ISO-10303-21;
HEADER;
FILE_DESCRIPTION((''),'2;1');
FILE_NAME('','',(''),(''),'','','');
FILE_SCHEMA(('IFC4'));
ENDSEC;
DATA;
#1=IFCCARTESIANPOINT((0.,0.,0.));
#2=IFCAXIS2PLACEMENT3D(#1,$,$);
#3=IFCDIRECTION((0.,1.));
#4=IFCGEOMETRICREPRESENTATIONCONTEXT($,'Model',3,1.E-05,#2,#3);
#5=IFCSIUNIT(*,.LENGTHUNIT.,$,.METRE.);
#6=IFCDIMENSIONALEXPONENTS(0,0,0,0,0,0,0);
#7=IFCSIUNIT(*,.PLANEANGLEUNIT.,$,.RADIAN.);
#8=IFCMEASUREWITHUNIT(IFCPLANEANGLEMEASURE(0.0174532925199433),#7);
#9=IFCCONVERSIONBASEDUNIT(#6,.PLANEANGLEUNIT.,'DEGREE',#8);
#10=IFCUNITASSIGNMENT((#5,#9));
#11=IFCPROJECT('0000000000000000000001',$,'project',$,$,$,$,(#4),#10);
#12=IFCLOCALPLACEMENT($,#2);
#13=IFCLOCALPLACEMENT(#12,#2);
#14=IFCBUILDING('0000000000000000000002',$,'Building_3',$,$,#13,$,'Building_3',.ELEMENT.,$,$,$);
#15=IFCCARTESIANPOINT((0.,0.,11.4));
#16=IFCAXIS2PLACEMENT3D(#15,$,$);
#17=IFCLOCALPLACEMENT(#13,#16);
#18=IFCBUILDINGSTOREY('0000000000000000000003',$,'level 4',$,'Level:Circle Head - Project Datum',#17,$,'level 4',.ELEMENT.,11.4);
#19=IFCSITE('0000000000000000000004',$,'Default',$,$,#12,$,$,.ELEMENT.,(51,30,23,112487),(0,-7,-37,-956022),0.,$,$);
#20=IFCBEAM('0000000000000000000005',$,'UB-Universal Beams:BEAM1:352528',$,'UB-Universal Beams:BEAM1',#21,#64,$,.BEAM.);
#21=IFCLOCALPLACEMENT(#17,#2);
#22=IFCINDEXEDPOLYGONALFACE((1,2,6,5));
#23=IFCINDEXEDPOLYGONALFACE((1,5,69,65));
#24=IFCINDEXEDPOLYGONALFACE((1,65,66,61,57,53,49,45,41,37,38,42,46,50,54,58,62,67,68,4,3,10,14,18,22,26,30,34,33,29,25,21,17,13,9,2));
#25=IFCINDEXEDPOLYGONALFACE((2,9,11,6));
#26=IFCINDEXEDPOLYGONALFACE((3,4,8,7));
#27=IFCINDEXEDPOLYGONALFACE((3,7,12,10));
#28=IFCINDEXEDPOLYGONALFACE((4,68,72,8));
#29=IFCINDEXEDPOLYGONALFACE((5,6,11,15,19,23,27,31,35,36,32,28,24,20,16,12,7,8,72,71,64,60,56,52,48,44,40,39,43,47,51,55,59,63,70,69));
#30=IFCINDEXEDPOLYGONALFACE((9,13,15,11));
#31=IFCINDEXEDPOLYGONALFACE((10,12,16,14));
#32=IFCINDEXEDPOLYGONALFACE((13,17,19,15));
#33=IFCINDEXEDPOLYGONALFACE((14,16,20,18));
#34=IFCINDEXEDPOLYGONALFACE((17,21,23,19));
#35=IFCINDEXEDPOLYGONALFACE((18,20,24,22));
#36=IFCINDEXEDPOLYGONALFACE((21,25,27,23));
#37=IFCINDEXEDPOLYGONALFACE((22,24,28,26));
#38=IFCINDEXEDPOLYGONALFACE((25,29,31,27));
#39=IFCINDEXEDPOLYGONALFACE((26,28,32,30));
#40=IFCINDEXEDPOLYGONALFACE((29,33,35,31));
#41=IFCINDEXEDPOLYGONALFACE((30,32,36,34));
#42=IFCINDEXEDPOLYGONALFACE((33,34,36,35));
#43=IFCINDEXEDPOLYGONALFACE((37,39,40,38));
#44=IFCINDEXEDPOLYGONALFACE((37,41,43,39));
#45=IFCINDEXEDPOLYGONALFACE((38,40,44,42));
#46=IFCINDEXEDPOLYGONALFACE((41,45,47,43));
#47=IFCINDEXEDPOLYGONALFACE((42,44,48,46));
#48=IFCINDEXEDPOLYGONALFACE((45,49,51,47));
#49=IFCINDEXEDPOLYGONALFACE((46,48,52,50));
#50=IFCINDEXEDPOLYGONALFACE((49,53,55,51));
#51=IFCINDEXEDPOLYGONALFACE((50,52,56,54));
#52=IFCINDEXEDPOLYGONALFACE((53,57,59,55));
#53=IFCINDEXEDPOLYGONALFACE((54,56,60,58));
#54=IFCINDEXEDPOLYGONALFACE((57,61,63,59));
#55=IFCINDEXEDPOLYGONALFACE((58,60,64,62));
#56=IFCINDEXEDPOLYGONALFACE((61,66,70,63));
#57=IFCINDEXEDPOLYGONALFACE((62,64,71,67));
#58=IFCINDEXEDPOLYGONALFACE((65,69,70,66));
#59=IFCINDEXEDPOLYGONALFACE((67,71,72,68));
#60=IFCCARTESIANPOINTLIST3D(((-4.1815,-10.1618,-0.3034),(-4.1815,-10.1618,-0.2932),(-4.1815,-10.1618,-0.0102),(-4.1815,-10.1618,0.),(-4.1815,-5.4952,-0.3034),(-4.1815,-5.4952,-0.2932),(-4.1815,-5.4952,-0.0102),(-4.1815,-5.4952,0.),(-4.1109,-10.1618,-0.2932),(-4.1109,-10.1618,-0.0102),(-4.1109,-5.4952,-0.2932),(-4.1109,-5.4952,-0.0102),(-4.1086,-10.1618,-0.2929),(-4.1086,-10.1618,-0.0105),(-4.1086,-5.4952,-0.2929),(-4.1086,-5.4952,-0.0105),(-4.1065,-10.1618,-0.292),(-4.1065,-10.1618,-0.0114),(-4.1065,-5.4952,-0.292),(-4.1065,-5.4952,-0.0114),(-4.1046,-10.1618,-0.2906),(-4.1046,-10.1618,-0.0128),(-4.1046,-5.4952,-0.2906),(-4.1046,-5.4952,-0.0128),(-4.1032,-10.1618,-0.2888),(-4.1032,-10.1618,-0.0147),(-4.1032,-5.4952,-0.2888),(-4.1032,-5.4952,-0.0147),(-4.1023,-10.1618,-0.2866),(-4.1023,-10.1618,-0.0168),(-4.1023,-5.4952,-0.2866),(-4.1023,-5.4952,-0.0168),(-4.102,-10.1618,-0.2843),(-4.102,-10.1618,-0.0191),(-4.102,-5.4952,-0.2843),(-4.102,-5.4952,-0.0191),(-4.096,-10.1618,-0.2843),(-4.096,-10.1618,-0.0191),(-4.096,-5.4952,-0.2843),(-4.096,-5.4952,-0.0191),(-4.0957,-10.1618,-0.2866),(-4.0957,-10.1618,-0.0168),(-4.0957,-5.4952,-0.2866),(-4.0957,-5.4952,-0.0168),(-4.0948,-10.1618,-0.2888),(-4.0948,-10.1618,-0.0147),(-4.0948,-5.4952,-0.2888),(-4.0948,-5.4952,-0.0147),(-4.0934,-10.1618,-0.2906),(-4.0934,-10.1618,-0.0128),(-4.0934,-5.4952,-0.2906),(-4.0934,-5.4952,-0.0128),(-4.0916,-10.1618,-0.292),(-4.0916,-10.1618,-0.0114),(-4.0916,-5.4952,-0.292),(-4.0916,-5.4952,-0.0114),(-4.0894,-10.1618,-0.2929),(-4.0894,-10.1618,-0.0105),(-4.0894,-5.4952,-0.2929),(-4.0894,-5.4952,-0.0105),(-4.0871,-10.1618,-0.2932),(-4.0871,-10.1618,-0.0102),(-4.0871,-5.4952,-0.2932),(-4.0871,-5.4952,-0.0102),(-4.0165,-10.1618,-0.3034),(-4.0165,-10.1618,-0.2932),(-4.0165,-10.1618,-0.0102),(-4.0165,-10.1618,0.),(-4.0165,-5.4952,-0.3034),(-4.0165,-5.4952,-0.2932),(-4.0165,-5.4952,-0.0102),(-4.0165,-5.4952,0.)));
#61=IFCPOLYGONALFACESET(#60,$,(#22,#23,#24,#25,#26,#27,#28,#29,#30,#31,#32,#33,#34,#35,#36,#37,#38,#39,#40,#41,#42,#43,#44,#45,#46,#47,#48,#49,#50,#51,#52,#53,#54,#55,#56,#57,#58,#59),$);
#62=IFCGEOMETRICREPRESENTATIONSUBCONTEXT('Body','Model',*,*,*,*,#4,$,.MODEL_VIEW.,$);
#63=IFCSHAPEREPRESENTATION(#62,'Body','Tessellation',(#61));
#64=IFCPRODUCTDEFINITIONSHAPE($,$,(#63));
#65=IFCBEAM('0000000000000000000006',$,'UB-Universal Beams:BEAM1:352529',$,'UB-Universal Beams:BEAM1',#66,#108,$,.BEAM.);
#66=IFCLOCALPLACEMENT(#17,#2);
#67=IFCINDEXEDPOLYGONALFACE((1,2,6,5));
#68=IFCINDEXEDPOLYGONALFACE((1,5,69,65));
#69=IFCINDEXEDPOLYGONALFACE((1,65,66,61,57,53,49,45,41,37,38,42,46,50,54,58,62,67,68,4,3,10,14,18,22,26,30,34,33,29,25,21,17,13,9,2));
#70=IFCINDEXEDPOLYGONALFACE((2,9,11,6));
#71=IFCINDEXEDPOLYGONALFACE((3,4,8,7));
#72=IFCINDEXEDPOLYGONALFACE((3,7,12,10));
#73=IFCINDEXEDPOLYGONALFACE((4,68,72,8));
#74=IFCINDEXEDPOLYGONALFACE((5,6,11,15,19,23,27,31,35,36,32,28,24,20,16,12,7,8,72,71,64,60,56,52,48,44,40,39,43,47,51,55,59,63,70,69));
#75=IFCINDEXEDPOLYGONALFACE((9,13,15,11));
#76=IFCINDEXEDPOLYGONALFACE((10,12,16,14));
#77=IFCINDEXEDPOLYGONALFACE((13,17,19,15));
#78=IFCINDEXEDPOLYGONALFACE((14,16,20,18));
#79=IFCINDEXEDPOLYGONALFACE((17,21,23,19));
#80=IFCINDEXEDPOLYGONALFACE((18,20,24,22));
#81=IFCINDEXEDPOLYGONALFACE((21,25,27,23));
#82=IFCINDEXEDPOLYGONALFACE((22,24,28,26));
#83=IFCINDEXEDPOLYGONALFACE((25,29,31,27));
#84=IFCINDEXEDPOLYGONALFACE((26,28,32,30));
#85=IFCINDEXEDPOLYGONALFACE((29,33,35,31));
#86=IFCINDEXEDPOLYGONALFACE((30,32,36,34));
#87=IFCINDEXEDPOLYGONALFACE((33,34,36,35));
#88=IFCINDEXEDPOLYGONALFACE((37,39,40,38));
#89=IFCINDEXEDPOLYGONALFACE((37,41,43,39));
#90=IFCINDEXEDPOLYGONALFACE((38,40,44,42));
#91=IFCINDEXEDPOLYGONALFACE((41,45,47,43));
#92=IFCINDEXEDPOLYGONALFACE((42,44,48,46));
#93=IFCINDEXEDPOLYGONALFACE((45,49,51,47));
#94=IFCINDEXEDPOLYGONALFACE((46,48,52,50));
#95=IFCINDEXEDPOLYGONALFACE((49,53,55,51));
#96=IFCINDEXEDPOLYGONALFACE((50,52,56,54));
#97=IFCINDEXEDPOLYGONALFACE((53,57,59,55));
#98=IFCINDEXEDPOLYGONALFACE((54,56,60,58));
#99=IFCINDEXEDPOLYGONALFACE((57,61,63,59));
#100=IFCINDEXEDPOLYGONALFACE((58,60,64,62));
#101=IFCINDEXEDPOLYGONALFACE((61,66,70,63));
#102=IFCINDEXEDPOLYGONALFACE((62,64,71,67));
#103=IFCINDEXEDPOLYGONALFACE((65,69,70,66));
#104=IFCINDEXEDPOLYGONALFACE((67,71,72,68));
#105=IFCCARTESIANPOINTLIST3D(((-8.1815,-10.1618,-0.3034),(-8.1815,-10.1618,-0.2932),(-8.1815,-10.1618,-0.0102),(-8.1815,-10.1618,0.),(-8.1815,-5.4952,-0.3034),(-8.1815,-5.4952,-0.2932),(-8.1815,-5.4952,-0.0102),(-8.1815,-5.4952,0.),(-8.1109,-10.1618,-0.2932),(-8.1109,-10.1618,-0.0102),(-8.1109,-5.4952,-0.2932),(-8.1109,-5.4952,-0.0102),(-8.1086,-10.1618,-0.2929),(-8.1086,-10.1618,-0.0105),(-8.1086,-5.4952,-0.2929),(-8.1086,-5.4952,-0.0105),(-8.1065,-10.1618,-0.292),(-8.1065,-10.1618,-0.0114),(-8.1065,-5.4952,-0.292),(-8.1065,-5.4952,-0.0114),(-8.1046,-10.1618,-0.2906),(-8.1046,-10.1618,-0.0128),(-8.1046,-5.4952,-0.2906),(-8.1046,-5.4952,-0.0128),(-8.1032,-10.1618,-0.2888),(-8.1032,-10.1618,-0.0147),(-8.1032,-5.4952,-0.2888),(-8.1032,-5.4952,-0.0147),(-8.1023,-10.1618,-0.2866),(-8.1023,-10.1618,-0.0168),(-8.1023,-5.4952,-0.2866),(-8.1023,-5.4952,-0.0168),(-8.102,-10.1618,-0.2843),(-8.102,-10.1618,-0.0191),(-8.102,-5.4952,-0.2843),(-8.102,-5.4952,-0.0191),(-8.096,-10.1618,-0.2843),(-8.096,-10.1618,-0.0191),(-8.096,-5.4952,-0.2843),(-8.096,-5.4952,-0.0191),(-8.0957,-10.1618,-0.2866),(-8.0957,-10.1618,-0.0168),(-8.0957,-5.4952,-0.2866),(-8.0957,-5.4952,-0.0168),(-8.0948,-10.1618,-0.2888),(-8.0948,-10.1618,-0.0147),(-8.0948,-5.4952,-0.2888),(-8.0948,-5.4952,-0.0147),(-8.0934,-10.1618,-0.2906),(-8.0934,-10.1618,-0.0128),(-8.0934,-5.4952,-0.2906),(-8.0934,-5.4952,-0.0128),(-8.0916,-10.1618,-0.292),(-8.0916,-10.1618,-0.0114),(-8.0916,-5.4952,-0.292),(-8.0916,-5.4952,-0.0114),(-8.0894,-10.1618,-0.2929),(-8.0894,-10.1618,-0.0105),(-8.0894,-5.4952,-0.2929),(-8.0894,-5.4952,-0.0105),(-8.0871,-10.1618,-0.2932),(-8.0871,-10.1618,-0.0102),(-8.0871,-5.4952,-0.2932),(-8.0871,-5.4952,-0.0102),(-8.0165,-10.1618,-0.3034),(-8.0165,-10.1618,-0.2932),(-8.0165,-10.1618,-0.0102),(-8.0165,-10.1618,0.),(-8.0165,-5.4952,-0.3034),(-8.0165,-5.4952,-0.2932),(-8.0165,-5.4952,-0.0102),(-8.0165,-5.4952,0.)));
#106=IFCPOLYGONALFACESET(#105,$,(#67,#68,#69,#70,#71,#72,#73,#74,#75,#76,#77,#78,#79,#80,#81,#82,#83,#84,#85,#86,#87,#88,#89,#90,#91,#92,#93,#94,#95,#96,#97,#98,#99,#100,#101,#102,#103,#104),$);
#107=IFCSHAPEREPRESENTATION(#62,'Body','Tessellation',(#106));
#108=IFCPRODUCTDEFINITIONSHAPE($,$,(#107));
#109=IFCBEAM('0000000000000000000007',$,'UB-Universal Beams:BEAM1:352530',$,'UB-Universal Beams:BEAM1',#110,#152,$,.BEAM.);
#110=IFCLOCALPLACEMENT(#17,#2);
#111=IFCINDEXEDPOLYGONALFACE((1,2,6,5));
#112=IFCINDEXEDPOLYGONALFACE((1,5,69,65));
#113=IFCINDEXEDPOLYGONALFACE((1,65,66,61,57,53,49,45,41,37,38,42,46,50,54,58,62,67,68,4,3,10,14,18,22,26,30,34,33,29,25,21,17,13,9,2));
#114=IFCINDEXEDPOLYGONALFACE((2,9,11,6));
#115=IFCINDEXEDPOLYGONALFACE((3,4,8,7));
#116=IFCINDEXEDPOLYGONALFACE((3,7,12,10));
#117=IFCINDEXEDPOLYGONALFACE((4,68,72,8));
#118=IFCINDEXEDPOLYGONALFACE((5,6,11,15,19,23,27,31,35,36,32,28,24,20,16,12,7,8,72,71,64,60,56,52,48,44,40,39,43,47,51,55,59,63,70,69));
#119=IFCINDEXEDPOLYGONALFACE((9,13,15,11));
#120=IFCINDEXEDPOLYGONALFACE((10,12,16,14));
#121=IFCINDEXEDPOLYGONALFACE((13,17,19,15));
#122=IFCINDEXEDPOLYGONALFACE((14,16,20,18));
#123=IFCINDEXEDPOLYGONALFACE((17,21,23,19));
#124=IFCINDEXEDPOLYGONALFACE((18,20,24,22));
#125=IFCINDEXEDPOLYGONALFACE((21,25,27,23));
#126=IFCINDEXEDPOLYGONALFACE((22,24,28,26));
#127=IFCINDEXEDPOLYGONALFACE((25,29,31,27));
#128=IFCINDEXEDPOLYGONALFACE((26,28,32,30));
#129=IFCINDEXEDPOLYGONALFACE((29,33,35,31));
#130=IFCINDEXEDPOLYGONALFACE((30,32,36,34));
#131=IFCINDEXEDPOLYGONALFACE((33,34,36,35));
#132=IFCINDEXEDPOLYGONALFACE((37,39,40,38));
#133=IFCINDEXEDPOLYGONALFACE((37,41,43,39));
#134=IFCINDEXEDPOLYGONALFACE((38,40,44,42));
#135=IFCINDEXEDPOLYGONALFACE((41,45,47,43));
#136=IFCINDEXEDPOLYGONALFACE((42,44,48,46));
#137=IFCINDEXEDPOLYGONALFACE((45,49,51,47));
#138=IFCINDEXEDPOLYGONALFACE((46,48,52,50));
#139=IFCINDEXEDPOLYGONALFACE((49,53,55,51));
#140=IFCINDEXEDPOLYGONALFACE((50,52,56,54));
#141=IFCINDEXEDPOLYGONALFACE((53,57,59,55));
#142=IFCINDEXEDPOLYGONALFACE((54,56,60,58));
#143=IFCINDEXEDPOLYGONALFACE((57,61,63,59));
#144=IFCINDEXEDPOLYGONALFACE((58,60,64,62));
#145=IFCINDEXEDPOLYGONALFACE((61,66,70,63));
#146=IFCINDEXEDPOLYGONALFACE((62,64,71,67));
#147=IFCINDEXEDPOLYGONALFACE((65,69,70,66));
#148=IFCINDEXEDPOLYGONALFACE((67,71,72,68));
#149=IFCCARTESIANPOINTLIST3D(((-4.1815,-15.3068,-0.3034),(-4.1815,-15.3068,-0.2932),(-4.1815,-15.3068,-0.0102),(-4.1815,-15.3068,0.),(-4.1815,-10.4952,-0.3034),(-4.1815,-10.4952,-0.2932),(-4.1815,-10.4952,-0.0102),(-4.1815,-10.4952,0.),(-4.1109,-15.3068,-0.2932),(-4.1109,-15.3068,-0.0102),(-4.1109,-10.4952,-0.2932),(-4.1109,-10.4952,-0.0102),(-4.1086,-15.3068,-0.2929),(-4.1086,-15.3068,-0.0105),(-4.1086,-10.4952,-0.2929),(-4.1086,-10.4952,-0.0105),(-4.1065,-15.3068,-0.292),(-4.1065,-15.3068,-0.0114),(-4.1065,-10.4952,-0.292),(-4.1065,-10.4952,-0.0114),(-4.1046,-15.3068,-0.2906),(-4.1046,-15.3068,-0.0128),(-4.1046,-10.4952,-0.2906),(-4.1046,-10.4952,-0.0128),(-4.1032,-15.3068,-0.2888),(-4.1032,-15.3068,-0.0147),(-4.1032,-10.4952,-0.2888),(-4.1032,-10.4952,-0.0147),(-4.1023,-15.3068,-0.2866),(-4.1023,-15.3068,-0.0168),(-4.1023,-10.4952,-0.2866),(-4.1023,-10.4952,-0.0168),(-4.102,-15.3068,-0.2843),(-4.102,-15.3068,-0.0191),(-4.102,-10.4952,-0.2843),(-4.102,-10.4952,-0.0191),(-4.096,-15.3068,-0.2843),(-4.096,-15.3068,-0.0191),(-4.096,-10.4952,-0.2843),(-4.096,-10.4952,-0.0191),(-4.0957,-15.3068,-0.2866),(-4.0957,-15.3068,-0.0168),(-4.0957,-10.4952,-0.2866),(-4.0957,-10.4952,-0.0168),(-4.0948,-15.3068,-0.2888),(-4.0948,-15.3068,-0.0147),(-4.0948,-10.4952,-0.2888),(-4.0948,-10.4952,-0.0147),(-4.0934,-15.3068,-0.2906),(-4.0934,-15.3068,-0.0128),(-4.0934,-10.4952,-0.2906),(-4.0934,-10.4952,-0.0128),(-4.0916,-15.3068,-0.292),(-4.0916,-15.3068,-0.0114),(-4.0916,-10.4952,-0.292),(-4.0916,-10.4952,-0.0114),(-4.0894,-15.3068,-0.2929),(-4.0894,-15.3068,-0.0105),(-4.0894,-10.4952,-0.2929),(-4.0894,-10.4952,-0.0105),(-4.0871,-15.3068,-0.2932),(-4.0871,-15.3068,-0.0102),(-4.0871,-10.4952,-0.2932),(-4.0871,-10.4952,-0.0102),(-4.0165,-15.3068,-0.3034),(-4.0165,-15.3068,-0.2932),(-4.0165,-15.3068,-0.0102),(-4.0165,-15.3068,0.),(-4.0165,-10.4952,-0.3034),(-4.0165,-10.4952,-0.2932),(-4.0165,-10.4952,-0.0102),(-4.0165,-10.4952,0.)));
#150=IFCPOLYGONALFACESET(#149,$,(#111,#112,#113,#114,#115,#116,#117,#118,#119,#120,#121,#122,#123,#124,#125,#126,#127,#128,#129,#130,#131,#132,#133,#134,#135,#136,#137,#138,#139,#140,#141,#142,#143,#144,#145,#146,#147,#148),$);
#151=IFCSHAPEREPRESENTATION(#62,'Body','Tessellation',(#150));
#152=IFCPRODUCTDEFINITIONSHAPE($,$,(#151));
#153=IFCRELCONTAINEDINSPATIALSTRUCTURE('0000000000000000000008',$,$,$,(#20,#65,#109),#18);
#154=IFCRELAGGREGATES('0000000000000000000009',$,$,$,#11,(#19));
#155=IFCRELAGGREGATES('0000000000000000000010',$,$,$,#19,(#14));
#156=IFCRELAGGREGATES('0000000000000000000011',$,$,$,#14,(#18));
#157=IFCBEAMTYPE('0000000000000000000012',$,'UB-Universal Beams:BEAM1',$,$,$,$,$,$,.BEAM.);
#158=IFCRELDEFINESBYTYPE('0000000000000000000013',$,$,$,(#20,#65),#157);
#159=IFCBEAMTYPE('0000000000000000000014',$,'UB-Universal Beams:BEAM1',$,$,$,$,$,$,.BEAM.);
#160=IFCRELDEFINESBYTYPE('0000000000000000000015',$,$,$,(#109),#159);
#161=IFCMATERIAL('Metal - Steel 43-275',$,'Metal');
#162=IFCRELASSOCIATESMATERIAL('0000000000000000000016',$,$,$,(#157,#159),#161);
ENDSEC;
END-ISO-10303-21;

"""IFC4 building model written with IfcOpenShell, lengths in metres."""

from ifc_helpers import new_model, entity, si_unit, converted_unit, direction, frame, frame_2d, origin, place, context, subcontext, project, spatial, polyline, circle_curve, parameter, trimmed, segment, composite_curve, outline, extrude, source, transform, mapped, material, material_profile, profile_set, type_object, type_shapes, element, save


model = new_model("IFC4")

# Units and contexts
model_context = context("Model", 3, precision=1e-05, world=origin(), true_north=direction((0.0, 1.0)))
body_context = subcontext(model_context, "Body", "Model", "MODEL_VIEW")
ifc_project = project(units=[si_unit("LENGTHUNIT", "METRE"), converted_unit("PLANEANGLEUNIT", "DEGREE", entity("IfcPlaneAngleMeasure", 0.0174532925199433), si_unit("PLANEANGLEUNIT", "RADIAN"), dimensions=[0, 0, 0, 0, 0, 0, 0])], contexts=[model_context])

# Site, building, storey
site_placement = place(None, origin())
site = spatial("IfcSite", under=ifc_project, at=site_placement, Name="Default", CompositionType="ELEMENT", RefLatitude=(51, 30, 23, 112487), RefLongitude=(0, -7, -37, -956022), RefElevation=0.0)
building_placement = place(site_placement, origin())
building = spatial("IfcBuilding", under=site, at=building_placement, Name="Building_3", LongName="Building_3", CompositionType="ELEMENT")
storey_placement = place(building_placement, frame((0.0, 0.0, 11.4)))
storey = spatial("IfcBuildingStorey", under=building, at=storey_placement, Name="level 4", ObjectType="Level:Circle Head - Project Datum", LongName="level 4", CompositionType="ELEMENT", Elevation=11.4)

# Shared definitions
ifc_material_1 = material(Name="Metal - Steel 43-275", Category="Metal")

# Beams
ifc_material_profile_1 = material_profile(ifc_material_1, outline(composite_curve([segment(polyline([(-0.0825, -0.1415), (-0.0825, -0.1517)]), True, "CONTINUOUS"), segment(polyline([(-0.0825, -0.1517), (0.0825, -0.1517)]), True, "CONTINUOUS"), segment(polyline([(0.0825, -0.1517), (0.0825, -0.1415)]), True, "CONTINUOUS"), segment(polyline([(0.0825, -0.1415), (0.0119, -0.1415)]), True, "CONTINUOUS"), segment(trimmed(circle_curve(frame_2d((0.0119, -0.1326), x_axis=(1.0, 0.0)), 0.0089), [parameter(180.0)], [parameter(270.0)], True, "PARAMETER"), False, "CONTINUOUS"), segment(polyline([(0.003, -0.1326), (0.003, 0.1326)]), True, "CONTINUOUS"), segment(trimmed(circle_curve(frame_2d((0.0119, 0.1326), x_axis=(1.0, 0.0)), 0.0089), [parameter(90.0)], [parameter(180.0)], True, "PARAMETER"), False, "CONTINUOUS"), segment(polyline([(0.0119, 0.1415), (0.0825, 0.1415)]), True, "CONTINUOUS"), segment(polyline([(0.0825, 0.1415), (0.0825, 0.1517)]), True, "CONTINUOUS"), segment(polyline([(0.0825, 0.1517), (-0.0825, 0.1517)]), True, "CONTINUOUS"), segment(polyline([(-0.0825, 0.1517), (-0.0825, 0.1415)]), True, "CONTINUOUS"), segment(polyline([(-0.0825, 0.1415), (-0.0119, 0.1415)]), True, "CONTINUOUS"), segment(trimmed(circle_curve(frame_2d((-0.0119, 0.1326), x_axis=(1.0, 0.0)), 0.0089), [parameter(360.0)], [parameter(90.0)], True, "PARAMETER"), False, "CONTINUOUS"), segment(polyline([(-0.003, 0.1326), (-0.003, -0.1326)]), True, "CONTINUOUS"), segment(trimmed(circle_curve(frame_2d((-0.0119, -0.1326), x_axis=(1.0, 0.0)), 0.0089), [parameter(270.0)], [parameter(360.0)], True, "PARAMETER"), False, "CONTINUOUS"), segment(polyline([(-0.0119, -0.1415), (-0.0825, -0.1415)]), True, "CONTINUOUS")], self_intersect=False)), Name="BEAM1")
ifc_profile_set_1 = profile_set([ifc_material_profile_1], Name="BEAM1")
beam_type_1 = type_object("IfcBeamType", Name="UB-Universal Beams:BEAM1", PredefinedType="BEAM", material=ifc_profile_set_1)
shared_shape_1 = source(origin(), body_context, "Body", "SweptSolid", [
    extrude(outline(composite_curve([segment(polyline([(-0.0825, -0.1415), (-0.0825, -0.1517)]), True, "CONTINUOUS"), segment(polyline([(-0.0825, -0.1517), (0.0825, -0.1517)]), True, "CONTINUOUS"), segment(polyline([(0.0825, -0.1517), (0.0825, -0.1415)]), True, "CONTINUOUS"), segment(polyline([(0.0825, -0.1415), (0.0119, -0.1415)]), True, "CONTINUOUS"), segment(trimmed(circle_curve(frame_2d((0.0119, -0.1326), x_axis=(0.0, -1.0)), 0.0089), [parameter(270.0)], [parameter(360.0)], True, "PARAMETER"), False, "CONTINUOUS"), segment(polyline([(0.003, -0.1326), (0.003, 0.1326)]), True, "CONTINUOUS"), segment(trimmed(circle_curve(frame_2d((0.0119, 0.1326), x_axis=(-1.0, 0.0)), 0.0089), [parameter(270.0)], [parameter(360.0)], True, "PARAMETER"), False, "CONTINUOUS"), segment(polyline([(0.0119, 0.1415), (0.0825, 0.1415)]), True, "CONTINUOUS"), segment(polyline([(0.0825, 0.1415), (0.0825, 0.1517)]), True, "CONTINUOUS"), segment(polyline([(0.0825, 0.1517), (-0.0825, 0.1517)]), True, "CONTINUOUS"), segment(polyline([(-0.0825, 0.1517), (-0.0825, 0.1415)]), True, "CONTINUOUS"), segment(polyline([(-0.0825, 0.1415), (-0.0119, 0.1415)]), True, "CONTINUOUS"), segment(trimmed(circle_curve(frame_2d((-0.0119, 0.1326), x_axis=(0.0, 1.0)), 0.0089), [parameter(270.0)], [parameter(360.0)], True, "PARAMETER"), False, "CONTINUOUS"), segment(polyline([(-0.003, 0.1326), (-0.003, -0.1326)]), True, "CONTINUOUS"), segment(trimmed(circle_curve(frame_2d((-0.0119, -0.1326), x_axis=(1.0, 0.0)), 0.0089), [parameter(270.0)], [parameter(0.0)], True, "PARAMETER"), False, "CONTINUOUS"), segment(polyline([(-0.0119, -0.1415), (-0.0825, -0.1415)]), True, "CONTINUOUS")], self_intersect=False)), frame((-2.3333, 0.0, 0.0), z_axis=(-1.0, 0.0, 0.0), x_axis=(0.0, -1.0, 0.0)), (0.0, 0.0, -1.0), 4.6666),
])
type_shapes(beam_type_1, [shared_shape_1])
for number, where, z_axis, x_axis, name in (
    (1, (-4.099, -7.8285, -0.1517), (0.0, 0.0, 1.0), (0.0, 1.0, 0.0), "UB-Universal Beams:BEAM1:352528"),
    (2, (-8.099, -7.8285, -0.1517), (0.0, 0.0, 1.0), (0.0, 1.0, 0.0), "UB-Universal Beams:BEAM1:352529"),
):
    element("IfcBeam", number, at=place(storey_placement, frame(where, z_axis=z_axis, x_axis=x_axis)), inside=storey, type_object=beam_type_1, Name=name, ObjectType="UB-Universal Beams:BEAM1", PredefinedType="BEAM", context=body_context, shape_type="MappedRepresentation", body=[
        mapped(shared_shape_1, transform((0.0, 0.0, 0.0), scale=1.0)),
    ])
beam_type_2 = type_object("IfcBeamType", Name="UB-Universal Beams:BEAM1", PredefinedType="BEAM", material=ifc_profile_set_1)
shared_shape_2 = source(origin(), body_context, "Body", "SweptSolid", [
    extrude(outline(composite_curve([segment(polyline([(-0.0825, -0.1415), (-0.0825, -0.1517)]), True, "CONTINUOUS"), segment(polyline([(-0.0825, -0.1517), (0.0825, -0.1517)]), True, "CONTINUOUS"), segment(polyline([(0.0825, -0.1517), (0.0825, -0.1415)]), True, "CONTINUOUS"), segment(polyline([(0.0825, -0.1415), (0.0119, -0.1415)]), True, "CONTINUOUS"), segment(trimmed(circle_curve(frame_2d((0.0119, -0.1326), x_axis=(0.0, -1.0)), 0.0089), [parameter(270.0)], [parameter(360.0)], True, "PARAMETER"), False, "CONTINUOUS"), segment(polyline([(0.003, -0.1326), (0.003, 0.1326)]), True, "CONTINUOUS"), segment(trimmed(circle_curve(frame_2d((0.0119, 0.1326), x_axis=(-1.0, 0.0)), 0.0089), [parameter(270.0)], [parameter(360.0)], True, "PARAMETER"), False, "CONTINUOUS"), segment(polyline([(0.0119, 0.1415), (0.0825, 0.1415)]), True, "CONTINUOUS"), segment(polyline([(0.0825, 0.1415), (0.0825, 0.1517)]), True, "CONTINUOUS"), segment(polyline([(0.0825, 0.1517), (-0.0825, 0.1517)]), True, "CONTINUOUS"), segment(polyline([(-0.0825, 0.1517), (-0.0825, 0.1415)]), True, "CONTINUOUS"), segment(polyline([(-0.0825, 0.1415), (-0.0119, 0.1415)]), True, "CONTINUOUS"), segment(trimmed(circle_curve(frame_2d((-0.0119, 0.1326), x_axis=(0.0, 1.0)), 0.0089), [parameter(270.0)], [parameter(360.0)], True, "PARAMETER"), False, "CONTINUOUS"), segment(polyline([(-0.003, 0.1326), (-0.003, -0.1326)]), True, "CONTINUOUS"), segment(trimmed(circle_curve(frame_2d((-0.0119, -0.1326), x_axis=(1.0, 0.0)), 0.0089), [parameter(270.0)], [parameter(0.0)], True, "PARAMETER"), False, "CONTINUOUS"), segment(polyline([(-0.0119, -0.1415), (-0.0825, -0.1415)]), True, "CONTINUOUS")], self_intersect=False)), frame((-2.4058, 0.0, 0.0), z_axis=(-1.0, 0.0, 0.0), x_axis=(0.0, -1.0, 0.0)), (0.0, 0.0, -1.0), 4.8116),
])
type_shapes(beam_type_2, [shared_shape_2])
for number, where, z_axis, x_axis, name in (
    (3, (-4.099, -12.901, -0.1517), (0.0, 0.0, 1.0), (0.0, 1.0, 0.0), "UB-Universal Beams:BEAM1:352530"),
):
    element("IfcBeam", number, at=place(storey_placement, frame(where, z_axis=z_axis, x_axis=x_axis)), inside=storey, type_object=beam_type_2, Name=name, ObjectType="UB-Universal Beams:BEAM1", PredefinedType="BEAM", context=body_context, shape_type="MappedRepresentation", body=[
        mapped(shared_shape_2, transform((0.0, 0.0, 0.0), scale=1.0)),
    ])

save(model, "model.ifc")
